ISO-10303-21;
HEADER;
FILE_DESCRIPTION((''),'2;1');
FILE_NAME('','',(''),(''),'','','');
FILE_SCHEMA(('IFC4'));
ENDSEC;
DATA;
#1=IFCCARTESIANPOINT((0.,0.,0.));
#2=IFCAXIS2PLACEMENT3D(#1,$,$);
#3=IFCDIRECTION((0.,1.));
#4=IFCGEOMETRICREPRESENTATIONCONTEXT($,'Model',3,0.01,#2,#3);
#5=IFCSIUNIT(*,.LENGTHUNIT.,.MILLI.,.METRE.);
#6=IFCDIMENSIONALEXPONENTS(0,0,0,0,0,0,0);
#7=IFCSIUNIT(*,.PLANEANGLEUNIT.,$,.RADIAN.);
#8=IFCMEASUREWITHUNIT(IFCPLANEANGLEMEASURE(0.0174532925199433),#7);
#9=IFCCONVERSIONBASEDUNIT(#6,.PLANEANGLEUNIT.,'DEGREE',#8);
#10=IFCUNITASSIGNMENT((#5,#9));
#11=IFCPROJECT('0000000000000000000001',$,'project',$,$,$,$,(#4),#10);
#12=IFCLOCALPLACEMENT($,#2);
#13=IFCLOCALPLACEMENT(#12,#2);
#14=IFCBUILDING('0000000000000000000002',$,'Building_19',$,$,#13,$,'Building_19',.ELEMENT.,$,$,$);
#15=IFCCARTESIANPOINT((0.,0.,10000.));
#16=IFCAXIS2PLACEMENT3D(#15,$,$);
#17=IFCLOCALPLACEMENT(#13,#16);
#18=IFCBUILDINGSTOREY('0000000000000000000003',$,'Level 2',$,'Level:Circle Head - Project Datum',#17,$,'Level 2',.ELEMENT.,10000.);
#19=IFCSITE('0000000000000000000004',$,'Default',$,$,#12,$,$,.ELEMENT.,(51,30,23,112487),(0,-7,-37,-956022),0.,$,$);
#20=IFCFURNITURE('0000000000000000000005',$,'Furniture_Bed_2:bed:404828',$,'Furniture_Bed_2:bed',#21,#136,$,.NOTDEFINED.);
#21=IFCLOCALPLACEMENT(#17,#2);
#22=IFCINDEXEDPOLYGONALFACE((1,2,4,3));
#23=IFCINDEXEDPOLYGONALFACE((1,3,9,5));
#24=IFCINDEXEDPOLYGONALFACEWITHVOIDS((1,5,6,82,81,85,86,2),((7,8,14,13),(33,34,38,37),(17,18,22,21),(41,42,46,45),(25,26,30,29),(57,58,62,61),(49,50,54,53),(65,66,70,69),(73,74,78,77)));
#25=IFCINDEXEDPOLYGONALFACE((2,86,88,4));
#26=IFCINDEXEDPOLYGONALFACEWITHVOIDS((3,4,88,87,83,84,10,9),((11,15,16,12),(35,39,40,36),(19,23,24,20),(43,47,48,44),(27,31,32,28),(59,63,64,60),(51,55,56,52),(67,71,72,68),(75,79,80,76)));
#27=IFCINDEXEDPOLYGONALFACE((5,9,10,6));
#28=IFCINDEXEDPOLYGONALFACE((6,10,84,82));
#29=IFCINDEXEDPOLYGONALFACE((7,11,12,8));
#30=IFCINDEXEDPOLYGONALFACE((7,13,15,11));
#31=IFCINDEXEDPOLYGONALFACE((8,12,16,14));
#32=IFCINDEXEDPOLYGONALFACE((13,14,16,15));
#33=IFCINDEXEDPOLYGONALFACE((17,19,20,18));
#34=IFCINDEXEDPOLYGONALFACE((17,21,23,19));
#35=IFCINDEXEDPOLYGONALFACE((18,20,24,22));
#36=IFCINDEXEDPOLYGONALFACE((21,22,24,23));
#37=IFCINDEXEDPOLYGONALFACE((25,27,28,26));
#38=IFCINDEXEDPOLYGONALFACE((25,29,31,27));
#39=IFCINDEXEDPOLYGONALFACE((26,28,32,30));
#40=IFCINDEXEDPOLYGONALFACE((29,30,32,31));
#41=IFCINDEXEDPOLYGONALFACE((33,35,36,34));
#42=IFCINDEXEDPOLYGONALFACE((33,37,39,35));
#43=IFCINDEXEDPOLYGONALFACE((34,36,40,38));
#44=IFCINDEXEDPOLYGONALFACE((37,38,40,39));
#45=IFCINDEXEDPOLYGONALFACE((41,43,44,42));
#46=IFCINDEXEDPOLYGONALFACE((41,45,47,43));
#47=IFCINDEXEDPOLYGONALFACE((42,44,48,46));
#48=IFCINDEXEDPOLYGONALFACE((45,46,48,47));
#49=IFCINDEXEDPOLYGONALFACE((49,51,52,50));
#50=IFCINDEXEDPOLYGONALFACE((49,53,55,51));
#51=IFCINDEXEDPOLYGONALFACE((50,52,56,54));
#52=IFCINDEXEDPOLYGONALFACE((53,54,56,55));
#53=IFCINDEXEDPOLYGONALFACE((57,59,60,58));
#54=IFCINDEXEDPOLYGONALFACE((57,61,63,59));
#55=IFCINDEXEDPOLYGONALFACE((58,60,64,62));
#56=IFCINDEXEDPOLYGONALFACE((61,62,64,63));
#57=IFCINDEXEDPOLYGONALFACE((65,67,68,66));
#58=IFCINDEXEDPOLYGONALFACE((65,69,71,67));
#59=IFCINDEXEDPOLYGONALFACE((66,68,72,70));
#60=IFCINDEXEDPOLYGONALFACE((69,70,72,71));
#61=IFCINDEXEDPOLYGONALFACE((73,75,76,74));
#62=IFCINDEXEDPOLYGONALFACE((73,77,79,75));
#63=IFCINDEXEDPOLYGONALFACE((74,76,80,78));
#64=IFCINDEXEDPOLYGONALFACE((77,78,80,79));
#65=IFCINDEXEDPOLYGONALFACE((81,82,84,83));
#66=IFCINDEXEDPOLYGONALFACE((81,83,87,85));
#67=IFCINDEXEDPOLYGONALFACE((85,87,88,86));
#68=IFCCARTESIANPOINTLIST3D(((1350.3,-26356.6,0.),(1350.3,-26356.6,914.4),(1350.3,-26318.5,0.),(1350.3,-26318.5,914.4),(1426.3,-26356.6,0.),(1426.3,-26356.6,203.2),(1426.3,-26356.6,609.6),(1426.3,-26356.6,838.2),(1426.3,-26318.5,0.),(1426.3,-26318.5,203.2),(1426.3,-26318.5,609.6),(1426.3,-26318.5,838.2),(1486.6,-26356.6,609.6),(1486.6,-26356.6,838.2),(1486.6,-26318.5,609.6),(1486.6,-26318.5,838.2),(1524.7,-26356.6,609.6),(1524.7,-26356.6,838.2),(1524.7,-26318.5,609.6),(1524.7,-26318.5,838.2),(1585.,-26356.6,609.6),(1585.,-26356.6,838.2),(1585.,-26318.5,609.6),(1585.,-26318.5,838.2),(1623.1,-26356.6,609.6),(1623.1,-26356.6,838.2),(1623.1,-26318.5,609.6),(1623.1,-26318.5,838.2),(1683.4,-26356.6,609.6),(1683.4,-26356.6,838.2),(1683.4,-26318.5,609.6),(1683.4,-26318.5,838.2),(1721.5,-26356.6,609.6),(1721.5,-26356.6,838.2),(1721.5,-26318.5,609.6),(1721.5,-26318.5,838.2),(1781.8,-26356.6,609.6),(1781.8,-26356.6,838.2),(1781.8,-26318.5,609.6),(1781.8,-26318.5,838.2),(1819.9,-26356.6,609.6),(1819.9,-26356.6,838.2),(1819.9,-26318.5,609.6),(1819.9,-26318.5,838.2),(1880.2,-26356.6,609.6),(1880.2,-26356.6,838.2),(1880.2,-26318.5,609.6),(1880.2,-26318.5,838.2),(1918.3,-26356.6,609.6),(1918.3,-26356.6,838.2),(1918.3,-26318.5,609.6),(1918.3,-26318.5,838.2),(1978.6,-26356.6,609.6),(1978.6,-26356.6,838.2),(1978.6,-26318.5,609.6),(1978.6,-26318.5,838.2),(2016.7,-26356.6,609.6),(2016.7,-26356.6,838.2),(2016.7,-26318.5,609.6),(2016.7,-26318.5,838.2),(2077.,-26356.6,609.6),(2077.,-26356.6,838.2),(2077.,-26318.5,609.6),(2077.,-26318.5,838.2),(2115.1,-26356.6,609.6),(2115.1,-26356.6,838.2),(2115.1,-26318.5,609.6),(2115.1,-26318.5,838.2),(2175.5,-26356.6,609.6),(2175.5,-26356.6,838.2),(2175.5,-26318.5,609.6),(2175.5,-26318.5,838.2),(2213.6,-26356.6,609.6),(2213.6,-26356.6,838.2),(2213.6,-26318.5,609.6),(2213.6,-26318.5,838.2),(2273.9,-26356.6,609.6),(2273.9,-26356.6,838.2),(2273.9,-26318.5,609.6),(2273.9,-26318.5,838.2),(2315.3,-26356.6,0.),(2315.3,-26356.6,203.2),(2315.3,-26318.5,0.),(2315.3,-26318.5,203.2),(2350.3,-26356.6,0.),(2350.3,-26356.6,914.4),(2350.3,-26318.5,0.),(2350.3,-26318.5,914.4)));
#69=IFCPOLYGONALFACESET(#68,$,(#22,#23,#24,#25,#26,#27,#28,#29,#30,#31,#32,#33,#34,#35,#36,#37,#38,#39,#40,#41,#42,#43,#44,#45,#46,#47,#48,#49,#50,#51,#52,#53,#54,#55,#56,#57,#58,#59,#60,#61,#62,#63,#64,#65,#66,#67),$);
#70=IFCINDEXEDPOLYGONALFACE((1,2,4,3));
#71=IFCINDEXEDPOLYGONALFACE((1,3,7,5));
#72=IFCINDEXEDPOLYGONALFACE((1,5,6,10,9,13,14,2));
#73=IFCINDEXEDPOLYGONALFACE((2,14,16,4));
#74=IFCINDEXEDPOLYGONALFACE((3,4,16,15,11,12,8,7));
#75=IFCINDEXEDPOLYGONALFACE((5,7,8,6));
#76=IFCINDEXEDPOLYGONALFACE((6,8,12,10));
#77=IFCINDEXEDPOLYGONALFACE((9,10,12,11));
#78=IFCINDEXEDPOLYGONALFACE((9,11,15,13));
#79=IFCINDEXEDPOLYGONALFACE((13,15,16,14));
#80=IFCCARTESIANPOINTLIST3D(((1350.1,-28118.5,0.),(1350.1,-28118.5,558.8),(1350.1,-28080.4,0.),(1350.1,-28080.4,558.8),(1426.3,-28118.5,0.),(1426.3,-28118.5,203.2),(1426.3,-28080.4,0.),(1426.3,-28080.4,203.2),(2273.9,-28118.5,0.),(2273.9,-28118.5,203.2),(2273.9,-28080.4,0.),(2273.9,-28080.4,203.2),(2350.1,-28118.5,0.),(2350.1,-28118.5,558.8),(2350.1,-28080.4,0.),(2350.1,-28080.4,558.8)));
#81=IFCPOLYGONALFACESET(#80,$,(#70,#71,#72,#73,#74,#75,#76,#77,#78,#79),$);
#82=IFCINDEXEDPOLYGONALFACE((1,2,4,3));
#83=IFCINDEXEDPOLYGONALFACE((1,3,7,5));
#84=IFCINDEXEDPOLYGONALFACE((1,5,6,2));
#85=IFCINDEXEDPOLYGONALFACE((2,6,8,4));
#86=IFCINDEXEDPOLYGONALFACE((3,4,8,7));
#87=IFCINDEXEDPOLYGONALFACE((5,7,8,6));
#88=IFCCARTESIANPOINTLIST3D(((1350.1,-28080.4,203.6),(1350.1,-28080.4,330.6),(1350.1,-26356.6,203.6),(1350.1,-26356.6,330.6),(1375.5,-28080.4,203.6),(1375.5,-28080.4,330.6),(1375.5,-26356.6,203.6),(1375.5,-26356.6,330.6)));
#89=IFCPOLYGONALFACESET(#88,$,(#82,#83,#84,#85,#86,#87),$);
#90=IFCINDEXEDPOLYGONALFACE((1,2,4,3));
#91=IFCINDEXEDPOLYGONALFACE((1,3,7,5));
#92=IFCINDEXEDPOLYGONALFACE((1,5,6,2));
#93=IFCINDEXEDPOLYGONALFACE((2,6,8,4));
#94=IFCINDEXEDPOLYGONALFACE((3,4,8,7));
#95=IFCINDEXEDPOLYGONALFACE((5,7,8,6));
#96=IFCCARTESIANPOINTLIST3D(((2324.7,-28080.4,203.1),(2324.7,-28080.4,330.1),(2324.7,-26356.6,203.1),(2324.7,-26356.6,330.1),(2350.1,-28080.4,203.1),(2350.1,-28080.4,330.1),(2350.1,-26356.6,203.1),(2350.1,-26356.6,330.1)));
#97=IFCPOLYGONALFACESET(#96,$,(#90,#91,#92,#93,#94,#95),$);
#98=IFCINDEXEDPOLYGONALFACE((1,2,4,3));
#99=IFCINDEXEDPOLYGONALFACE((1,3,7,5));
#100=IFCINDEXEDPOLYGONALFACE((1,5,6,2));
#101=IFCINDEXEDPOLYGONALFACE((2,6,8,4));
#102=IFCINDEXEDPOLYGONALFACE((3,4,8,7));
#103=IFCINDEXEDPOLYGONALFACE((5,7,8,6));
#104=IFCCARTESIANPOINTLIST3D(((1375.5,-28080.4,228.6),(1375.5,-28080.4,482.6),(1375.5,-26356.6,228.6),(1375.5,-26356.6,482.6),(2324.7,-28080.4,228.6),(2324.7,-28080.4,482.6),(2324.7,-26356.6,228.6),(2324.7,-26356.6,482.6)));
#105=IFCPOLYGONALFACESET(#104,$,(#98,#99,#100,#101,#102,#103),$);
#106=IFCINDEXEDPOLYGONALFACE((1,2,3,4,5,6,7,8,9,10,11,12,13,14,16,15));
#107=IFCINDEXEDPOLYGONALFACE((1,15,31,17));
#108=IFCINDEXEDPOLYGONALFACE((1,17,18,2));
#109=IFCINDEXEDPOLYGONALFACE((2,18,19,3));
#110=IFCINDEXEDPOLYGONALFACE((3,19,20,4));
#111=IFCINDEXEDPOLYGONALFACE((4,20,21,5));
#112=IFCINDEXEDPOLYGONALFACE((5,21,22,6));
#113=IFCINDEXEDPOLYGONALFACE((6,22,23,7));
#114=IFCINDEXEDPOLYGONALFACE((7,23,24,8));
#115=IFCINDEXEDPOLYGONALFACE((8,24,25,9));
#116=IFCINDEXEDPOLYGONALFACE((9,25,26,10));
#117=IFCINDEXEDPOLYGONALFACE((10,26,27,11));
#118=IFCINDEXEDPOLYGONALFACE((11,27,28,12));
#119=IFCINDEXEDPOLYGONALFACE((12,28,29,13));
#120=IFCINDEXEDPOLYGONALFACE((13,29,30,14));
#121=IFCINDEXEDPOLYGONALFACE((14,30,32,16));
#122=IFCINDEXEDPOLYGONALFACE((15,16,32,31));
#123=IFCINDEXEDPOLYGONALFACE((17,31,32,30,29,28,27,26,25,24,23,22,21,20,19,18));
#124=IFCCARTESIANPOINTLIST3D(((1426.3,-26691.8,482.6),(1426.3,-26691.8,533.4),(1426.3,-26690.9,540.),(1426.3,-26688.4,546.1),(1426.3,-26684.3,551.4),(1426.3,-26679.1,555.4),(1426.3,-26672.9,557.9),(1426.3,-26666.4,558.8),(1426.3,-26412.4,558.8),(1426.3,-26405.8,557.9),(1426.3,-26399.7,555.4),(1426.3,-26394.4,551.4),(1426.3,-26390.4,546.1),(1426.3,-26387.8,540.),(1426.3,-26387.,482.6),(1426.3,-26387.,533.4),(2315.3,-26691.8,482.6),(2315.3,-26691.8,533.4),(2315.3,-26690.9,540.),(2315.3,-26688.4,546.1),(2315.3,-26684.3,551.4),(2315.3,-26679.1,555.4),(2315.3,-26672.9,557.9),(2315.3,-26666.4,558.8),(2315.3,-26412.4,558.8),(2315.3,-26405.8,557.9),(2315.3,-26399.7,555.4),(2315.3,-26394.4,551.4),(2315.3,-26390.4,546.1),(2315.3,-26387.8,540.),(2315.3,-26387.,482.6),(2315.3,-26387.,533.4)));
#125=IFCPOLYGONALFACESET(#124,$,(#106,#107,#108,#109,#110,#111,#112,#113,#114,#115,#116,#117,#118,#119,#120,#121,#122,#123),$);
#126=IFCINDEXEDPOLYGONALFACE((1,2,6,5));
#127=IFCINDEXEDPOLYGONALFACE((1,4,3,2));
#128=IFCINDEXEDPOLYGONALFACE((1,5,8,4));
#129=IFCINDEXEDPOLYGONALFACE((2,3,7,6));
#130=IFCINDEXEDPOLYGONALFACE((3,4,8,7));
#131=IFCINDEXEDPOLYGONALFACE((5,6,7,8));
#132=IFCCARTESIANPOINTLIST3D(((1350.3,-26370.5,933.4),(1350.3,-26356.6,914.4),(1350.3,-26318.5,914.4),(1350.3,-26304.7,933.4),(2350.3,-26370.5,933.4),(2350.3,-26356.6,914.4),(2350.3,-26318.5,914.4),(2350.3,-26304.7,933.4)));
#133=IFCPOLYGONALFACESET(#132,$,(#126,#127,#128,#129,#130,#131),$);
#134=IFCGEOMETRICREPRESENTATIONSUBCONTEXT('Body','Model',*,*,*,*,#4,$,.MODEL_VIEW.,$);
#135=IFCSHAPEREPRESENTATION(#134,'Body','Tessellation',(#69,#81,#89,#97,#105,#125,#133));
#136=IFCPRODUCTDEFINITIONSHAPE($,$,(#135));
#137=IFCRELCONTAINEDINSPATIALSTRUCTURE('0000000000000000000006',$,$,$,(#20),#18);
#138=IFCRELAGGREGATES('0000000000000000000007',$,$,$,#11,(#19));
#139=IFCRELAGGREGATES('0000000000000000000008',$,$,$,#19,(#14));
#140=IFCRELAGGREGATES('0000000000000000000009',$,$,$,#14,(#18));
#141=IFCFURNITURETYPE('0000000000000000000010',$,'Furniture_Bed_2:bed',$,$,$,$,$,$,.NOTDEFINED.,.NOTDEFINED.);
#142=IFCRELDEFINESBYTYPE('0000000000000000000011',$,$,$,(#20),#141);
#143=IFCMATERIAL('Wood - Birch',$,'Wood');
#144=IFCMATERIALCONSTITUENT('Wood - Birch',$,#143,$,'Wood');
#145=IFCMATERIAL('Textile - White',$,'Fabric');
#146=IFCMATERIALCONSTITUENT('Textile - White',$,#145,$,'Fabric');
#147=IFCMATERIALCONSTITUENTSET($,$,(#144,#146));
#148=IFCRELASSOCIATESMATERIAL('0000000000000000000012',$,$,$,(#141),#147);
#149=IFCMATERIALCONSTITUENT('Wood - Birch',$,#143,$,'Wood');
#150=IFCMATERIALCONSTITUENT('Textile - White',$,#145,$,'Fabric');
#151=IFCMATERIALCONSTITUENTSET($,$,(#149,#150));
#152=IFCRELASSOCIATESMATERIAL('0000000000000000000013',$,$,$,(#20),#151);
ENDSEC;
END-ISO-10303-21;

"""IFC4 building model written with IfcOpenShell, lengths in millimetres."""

from ifc_helpers import new_model, entity, si_unit, converted_unit, direction, frame, origin, place, context, subcontext, project, spatial, line, arc, indexed_curve, outline, extrude, source, transform, mapped, material, constituent, constituent_set, type_object, type_shapes, element, save


model = new_model("IFC4")

# Units and contexts
model_context = context("Model", 3, precision=0.01, world=origin(), true_north=direction((0.0, 1.0)))
body_context = subcontext(model_context, "Body", "Model", "MODEL_VIEW")
ifc_project = project(units=[si_unit("LENGTHUNIT", "METRE", prefix="MILLI"), converted_unit("PLANEANGLEUNIT", "DEGREE", entity("IfcPlaneAngleMeasure", 0.0174532925199433), si_unit("PLANEANGLEUNIT", "RADIAN"), dimensions=[0, 0, 0, 0, 0, 0, 0])], contexts=[model_context])

# Site, building, storey
site_placement = place(None, origin())
site = spatial("IfcSite", under=ifc_project, at=site_placement, Name="Default", CompositionType="ELEMENT", RefLatitude=(51, 30, 23, 112487), RefLongitude=(0, -7, -37, -956022), RefElevation=0.0)
building_placement = place(site_placement, origin())
building = spatial("IfcBuilding", under=site, at=building_placement, Name="Building_19", LongName="Building_19", CompositionType="ELEMENT")
storey_placement = place(building_placement, frame((0.0, 0.0, 10000.0)))
storey = spatial("IfcBuildingStorey", under=building, at=storey_placement, Name="Level 2", ObjectType="Level:Circle Head - Project Datum", LongName="Level 2", CompositionType="ELEMENT", Elevation=10000.0)

# Furniture
ifc_material_1 = material(Name="Wood - Birch", Category="Wood")
ifc_material_2 = material(Name="Textile - White", Category="Fabric")
ifc_constituent_1 = constituent(ifc_material_1, Name="Wood - Birch", Category="Wood")
ifc_constituent_2 = constituent(ifc_material_2, Name="Textile - White", Category="Fabric")
ifc_constituent_set_1 = constituent_set(constituents=[ifc_constituent_1, ifc_constituent_2])
furniture_type_1 = type_object("IfcFurnitureType", Name="Furniture_Bed_2:bed", AssemblyPlace="NOTDEFINED", PredefinedType="NOTDEFINED", material=ifc_constituent_set_1)
shared_shape_1 = source(origin(), body_context, "Body", "SweptSolid", [
    extrude(outline(indexed_curve([(-635.0, -489.8), (279.4, -489.8), (279.4, -454.7), (76.2, -454.7), (76.2, 434.3), (279.4, 434.3), (279.4, 510.3), (-635.0, 510.3), (-635.0, -489.8)], self_intersect=False), holes=[indexed_curve([(-558.8, 374.0), (-558.8, 434.3), (-330.2, 434.3), (-330.2, 374.0), (-558.8, 374.0)], self_intersect=False), indexed_curve([(-558.8, 275.5), (-558.8, 335.9), (-330.2, 335.9), (-330.2, 275.5), (-558.8, 275.5)], self_intersect=False), indexed_curve([(-558.8, 177.1), (-558.8, 237.4), (-330.2, 237.4), (-330.2, 177.1), (-558.8, 177.1)], self_intersect=False), indexed_curve([(-558.8, 78.7), (-558.8, 139.0), (-330.2, 139.0), (-330.2, 78.7), (-558.8, 78.7)], self_intersect=False), indexed_curve([(-558.8, -118.1), (-558.8, -57.8), (-330.2, -57.8), (-330.2, -118.1), (-558.8, -118.1)], self_intersect=False), indexed_curve([(-558.8, -216.5), (-558.8, -156.2), (-330.2, -156.2), (-330.2, -216.5), (-558.8, -216.5)], self_intersect=False), indexed_curve([(-558.8, -314.9), (-558.8, -254.6), (-330.2, -254.6), (-330.2, -314.9), (-558.8, -314.9)], self_intersect=False), indexed_curve([(-558.8, -413.3), (-558.8, -353.0), (-330.2, -353.0), (-330.2, -413.3), (-558.8, -413.3)], self_intersect=False), indexed_curve([(-558.8, -19.7), (-558.8, 40.6), (-330.2, 40.6), (-330.2, -19.7), (-558.8, -19.7)], self_intersect=False)]), frame((-8.6, -38.1, 279.4), z_axis=(0.0, 1.0, 0.0), x_axis=(0.0, 0.0, -1.0)), (0.0, 0.0, 1.0), 38.1),
    extrude(outline(indexed_curve([(423.8, -190.5), (500.0, -190.5), (500.0, 368.3), (-500.0, 368.3), (-500.0, -190.5), (-423.8, -190.5), (-423.8, 12.7), (423.8, 12.7), (423.8, -190.5)], self_intersect=False)), frame((-19.1, -1800.0, 190.5), z_axis=(0.0, 1.0, 0.0), x_axis=(-1.0, 0.0, 0.0)), (0.0, 0.0, 1.0), 38.1),
    extrude(outline(indexed_curve([(-12.7, -861.9), (12.7, -861.9), (12.7, 861.9), (-12.7, 861.9), (-12.7, -861.9)], self_intersect=False)), frame((-506.4, -900.0, 203.6)), (0.0, 0.0, 1.0), 127.0),
    extrude(outline(indexed_curve([(-12.7, -861.9), (12.7, -861.9), (12.7, 861.9), (-12.7, 861.9), (-12.7, -861.9)], self_intersect=False)), frame((468.2, -900.0, 203.1)), (0.0, 0.0, 1.0), 127.0),
    extrude(outline(indexed_curve([(-474.6, -861.9), (474.6, -861.9), (474.6, 861.9), (-474.6, 861.9), (-474.6, -861.9)], self_intersect=False)), frame((-19.0, -900.0, 228.6), z_axis=(0.0, 0.0, 1.0), x_axis=(-1.0, 0.0, 0.0)), (0.0, 0.0, 1.0), 254.0),
    extrude(outline(indexed_curve([(-152.4, -42.3), (152.4, -42.3), (152.4, 8.5), (145.0, 26.4), (127.0, 33.9), (-127.0, 33.9), (-145.0, 26.4), (-152.4, 8.5)], segments=[line(1, 2, 3), arc(3, 4, 5), line(5, 6), arc(6, 7, 8), line(8, 1)], self_intersect=False)), frame((-442.9, -220.8, 524.9), z_axis=(1.0, 0.0, 0.0), x_axis=(0.0, 1.0, 0.0)), (0.0, 0.0, 1.0), 889.0),
    extrude(outline(indexed_curve([(-19.1, -9.5), (19.0, -9.5), (32.9, 9.5), (-32.9, 9.5), (-19.1, -9.5)], self_intersect=False)), frame((-518.8, -19.0, 923.9), z_axis=(1.0, 0.0, 0.0), x_axis=(0.0, 1.0, 0.0)), (0.0, 0.0, 1.0), 1000.1),
])
type_shapes(furniture_type_1, [shared_shape_1])
ifc_constituent_3 = constituent(ifc_material_1, Name="Wood - Birch", Category="Wood")
ifc_constituent_4 = constituent(ifc_material_2, Name="Textile - White", Category="Fabric")
ifc_constituent_set_2 = constituent_set(constituents=[ifc_constituent_3, ifc_constituent_4])
furniture_1_placement = place(storey_placement, frame((1869.1, -26318.5, 0.0)))
element("IfcFurniture", 1, at=furniture_1_placement, inside=storey, type_object=furniture_type_1, material=ifc_constituent_set_2, Name="Furniture_Bed_2:bed:404828", ObjectType="Furniture_Bed_2:bed", PredefinedType="NOTDEFINED", context=body_context, shape_type="MappedRepresentation", body=[
    mapped(shared_shape_1, transform((0.0, 0.0, 0.0), scale=1.0)),
])

save(model, "model.ifc")
